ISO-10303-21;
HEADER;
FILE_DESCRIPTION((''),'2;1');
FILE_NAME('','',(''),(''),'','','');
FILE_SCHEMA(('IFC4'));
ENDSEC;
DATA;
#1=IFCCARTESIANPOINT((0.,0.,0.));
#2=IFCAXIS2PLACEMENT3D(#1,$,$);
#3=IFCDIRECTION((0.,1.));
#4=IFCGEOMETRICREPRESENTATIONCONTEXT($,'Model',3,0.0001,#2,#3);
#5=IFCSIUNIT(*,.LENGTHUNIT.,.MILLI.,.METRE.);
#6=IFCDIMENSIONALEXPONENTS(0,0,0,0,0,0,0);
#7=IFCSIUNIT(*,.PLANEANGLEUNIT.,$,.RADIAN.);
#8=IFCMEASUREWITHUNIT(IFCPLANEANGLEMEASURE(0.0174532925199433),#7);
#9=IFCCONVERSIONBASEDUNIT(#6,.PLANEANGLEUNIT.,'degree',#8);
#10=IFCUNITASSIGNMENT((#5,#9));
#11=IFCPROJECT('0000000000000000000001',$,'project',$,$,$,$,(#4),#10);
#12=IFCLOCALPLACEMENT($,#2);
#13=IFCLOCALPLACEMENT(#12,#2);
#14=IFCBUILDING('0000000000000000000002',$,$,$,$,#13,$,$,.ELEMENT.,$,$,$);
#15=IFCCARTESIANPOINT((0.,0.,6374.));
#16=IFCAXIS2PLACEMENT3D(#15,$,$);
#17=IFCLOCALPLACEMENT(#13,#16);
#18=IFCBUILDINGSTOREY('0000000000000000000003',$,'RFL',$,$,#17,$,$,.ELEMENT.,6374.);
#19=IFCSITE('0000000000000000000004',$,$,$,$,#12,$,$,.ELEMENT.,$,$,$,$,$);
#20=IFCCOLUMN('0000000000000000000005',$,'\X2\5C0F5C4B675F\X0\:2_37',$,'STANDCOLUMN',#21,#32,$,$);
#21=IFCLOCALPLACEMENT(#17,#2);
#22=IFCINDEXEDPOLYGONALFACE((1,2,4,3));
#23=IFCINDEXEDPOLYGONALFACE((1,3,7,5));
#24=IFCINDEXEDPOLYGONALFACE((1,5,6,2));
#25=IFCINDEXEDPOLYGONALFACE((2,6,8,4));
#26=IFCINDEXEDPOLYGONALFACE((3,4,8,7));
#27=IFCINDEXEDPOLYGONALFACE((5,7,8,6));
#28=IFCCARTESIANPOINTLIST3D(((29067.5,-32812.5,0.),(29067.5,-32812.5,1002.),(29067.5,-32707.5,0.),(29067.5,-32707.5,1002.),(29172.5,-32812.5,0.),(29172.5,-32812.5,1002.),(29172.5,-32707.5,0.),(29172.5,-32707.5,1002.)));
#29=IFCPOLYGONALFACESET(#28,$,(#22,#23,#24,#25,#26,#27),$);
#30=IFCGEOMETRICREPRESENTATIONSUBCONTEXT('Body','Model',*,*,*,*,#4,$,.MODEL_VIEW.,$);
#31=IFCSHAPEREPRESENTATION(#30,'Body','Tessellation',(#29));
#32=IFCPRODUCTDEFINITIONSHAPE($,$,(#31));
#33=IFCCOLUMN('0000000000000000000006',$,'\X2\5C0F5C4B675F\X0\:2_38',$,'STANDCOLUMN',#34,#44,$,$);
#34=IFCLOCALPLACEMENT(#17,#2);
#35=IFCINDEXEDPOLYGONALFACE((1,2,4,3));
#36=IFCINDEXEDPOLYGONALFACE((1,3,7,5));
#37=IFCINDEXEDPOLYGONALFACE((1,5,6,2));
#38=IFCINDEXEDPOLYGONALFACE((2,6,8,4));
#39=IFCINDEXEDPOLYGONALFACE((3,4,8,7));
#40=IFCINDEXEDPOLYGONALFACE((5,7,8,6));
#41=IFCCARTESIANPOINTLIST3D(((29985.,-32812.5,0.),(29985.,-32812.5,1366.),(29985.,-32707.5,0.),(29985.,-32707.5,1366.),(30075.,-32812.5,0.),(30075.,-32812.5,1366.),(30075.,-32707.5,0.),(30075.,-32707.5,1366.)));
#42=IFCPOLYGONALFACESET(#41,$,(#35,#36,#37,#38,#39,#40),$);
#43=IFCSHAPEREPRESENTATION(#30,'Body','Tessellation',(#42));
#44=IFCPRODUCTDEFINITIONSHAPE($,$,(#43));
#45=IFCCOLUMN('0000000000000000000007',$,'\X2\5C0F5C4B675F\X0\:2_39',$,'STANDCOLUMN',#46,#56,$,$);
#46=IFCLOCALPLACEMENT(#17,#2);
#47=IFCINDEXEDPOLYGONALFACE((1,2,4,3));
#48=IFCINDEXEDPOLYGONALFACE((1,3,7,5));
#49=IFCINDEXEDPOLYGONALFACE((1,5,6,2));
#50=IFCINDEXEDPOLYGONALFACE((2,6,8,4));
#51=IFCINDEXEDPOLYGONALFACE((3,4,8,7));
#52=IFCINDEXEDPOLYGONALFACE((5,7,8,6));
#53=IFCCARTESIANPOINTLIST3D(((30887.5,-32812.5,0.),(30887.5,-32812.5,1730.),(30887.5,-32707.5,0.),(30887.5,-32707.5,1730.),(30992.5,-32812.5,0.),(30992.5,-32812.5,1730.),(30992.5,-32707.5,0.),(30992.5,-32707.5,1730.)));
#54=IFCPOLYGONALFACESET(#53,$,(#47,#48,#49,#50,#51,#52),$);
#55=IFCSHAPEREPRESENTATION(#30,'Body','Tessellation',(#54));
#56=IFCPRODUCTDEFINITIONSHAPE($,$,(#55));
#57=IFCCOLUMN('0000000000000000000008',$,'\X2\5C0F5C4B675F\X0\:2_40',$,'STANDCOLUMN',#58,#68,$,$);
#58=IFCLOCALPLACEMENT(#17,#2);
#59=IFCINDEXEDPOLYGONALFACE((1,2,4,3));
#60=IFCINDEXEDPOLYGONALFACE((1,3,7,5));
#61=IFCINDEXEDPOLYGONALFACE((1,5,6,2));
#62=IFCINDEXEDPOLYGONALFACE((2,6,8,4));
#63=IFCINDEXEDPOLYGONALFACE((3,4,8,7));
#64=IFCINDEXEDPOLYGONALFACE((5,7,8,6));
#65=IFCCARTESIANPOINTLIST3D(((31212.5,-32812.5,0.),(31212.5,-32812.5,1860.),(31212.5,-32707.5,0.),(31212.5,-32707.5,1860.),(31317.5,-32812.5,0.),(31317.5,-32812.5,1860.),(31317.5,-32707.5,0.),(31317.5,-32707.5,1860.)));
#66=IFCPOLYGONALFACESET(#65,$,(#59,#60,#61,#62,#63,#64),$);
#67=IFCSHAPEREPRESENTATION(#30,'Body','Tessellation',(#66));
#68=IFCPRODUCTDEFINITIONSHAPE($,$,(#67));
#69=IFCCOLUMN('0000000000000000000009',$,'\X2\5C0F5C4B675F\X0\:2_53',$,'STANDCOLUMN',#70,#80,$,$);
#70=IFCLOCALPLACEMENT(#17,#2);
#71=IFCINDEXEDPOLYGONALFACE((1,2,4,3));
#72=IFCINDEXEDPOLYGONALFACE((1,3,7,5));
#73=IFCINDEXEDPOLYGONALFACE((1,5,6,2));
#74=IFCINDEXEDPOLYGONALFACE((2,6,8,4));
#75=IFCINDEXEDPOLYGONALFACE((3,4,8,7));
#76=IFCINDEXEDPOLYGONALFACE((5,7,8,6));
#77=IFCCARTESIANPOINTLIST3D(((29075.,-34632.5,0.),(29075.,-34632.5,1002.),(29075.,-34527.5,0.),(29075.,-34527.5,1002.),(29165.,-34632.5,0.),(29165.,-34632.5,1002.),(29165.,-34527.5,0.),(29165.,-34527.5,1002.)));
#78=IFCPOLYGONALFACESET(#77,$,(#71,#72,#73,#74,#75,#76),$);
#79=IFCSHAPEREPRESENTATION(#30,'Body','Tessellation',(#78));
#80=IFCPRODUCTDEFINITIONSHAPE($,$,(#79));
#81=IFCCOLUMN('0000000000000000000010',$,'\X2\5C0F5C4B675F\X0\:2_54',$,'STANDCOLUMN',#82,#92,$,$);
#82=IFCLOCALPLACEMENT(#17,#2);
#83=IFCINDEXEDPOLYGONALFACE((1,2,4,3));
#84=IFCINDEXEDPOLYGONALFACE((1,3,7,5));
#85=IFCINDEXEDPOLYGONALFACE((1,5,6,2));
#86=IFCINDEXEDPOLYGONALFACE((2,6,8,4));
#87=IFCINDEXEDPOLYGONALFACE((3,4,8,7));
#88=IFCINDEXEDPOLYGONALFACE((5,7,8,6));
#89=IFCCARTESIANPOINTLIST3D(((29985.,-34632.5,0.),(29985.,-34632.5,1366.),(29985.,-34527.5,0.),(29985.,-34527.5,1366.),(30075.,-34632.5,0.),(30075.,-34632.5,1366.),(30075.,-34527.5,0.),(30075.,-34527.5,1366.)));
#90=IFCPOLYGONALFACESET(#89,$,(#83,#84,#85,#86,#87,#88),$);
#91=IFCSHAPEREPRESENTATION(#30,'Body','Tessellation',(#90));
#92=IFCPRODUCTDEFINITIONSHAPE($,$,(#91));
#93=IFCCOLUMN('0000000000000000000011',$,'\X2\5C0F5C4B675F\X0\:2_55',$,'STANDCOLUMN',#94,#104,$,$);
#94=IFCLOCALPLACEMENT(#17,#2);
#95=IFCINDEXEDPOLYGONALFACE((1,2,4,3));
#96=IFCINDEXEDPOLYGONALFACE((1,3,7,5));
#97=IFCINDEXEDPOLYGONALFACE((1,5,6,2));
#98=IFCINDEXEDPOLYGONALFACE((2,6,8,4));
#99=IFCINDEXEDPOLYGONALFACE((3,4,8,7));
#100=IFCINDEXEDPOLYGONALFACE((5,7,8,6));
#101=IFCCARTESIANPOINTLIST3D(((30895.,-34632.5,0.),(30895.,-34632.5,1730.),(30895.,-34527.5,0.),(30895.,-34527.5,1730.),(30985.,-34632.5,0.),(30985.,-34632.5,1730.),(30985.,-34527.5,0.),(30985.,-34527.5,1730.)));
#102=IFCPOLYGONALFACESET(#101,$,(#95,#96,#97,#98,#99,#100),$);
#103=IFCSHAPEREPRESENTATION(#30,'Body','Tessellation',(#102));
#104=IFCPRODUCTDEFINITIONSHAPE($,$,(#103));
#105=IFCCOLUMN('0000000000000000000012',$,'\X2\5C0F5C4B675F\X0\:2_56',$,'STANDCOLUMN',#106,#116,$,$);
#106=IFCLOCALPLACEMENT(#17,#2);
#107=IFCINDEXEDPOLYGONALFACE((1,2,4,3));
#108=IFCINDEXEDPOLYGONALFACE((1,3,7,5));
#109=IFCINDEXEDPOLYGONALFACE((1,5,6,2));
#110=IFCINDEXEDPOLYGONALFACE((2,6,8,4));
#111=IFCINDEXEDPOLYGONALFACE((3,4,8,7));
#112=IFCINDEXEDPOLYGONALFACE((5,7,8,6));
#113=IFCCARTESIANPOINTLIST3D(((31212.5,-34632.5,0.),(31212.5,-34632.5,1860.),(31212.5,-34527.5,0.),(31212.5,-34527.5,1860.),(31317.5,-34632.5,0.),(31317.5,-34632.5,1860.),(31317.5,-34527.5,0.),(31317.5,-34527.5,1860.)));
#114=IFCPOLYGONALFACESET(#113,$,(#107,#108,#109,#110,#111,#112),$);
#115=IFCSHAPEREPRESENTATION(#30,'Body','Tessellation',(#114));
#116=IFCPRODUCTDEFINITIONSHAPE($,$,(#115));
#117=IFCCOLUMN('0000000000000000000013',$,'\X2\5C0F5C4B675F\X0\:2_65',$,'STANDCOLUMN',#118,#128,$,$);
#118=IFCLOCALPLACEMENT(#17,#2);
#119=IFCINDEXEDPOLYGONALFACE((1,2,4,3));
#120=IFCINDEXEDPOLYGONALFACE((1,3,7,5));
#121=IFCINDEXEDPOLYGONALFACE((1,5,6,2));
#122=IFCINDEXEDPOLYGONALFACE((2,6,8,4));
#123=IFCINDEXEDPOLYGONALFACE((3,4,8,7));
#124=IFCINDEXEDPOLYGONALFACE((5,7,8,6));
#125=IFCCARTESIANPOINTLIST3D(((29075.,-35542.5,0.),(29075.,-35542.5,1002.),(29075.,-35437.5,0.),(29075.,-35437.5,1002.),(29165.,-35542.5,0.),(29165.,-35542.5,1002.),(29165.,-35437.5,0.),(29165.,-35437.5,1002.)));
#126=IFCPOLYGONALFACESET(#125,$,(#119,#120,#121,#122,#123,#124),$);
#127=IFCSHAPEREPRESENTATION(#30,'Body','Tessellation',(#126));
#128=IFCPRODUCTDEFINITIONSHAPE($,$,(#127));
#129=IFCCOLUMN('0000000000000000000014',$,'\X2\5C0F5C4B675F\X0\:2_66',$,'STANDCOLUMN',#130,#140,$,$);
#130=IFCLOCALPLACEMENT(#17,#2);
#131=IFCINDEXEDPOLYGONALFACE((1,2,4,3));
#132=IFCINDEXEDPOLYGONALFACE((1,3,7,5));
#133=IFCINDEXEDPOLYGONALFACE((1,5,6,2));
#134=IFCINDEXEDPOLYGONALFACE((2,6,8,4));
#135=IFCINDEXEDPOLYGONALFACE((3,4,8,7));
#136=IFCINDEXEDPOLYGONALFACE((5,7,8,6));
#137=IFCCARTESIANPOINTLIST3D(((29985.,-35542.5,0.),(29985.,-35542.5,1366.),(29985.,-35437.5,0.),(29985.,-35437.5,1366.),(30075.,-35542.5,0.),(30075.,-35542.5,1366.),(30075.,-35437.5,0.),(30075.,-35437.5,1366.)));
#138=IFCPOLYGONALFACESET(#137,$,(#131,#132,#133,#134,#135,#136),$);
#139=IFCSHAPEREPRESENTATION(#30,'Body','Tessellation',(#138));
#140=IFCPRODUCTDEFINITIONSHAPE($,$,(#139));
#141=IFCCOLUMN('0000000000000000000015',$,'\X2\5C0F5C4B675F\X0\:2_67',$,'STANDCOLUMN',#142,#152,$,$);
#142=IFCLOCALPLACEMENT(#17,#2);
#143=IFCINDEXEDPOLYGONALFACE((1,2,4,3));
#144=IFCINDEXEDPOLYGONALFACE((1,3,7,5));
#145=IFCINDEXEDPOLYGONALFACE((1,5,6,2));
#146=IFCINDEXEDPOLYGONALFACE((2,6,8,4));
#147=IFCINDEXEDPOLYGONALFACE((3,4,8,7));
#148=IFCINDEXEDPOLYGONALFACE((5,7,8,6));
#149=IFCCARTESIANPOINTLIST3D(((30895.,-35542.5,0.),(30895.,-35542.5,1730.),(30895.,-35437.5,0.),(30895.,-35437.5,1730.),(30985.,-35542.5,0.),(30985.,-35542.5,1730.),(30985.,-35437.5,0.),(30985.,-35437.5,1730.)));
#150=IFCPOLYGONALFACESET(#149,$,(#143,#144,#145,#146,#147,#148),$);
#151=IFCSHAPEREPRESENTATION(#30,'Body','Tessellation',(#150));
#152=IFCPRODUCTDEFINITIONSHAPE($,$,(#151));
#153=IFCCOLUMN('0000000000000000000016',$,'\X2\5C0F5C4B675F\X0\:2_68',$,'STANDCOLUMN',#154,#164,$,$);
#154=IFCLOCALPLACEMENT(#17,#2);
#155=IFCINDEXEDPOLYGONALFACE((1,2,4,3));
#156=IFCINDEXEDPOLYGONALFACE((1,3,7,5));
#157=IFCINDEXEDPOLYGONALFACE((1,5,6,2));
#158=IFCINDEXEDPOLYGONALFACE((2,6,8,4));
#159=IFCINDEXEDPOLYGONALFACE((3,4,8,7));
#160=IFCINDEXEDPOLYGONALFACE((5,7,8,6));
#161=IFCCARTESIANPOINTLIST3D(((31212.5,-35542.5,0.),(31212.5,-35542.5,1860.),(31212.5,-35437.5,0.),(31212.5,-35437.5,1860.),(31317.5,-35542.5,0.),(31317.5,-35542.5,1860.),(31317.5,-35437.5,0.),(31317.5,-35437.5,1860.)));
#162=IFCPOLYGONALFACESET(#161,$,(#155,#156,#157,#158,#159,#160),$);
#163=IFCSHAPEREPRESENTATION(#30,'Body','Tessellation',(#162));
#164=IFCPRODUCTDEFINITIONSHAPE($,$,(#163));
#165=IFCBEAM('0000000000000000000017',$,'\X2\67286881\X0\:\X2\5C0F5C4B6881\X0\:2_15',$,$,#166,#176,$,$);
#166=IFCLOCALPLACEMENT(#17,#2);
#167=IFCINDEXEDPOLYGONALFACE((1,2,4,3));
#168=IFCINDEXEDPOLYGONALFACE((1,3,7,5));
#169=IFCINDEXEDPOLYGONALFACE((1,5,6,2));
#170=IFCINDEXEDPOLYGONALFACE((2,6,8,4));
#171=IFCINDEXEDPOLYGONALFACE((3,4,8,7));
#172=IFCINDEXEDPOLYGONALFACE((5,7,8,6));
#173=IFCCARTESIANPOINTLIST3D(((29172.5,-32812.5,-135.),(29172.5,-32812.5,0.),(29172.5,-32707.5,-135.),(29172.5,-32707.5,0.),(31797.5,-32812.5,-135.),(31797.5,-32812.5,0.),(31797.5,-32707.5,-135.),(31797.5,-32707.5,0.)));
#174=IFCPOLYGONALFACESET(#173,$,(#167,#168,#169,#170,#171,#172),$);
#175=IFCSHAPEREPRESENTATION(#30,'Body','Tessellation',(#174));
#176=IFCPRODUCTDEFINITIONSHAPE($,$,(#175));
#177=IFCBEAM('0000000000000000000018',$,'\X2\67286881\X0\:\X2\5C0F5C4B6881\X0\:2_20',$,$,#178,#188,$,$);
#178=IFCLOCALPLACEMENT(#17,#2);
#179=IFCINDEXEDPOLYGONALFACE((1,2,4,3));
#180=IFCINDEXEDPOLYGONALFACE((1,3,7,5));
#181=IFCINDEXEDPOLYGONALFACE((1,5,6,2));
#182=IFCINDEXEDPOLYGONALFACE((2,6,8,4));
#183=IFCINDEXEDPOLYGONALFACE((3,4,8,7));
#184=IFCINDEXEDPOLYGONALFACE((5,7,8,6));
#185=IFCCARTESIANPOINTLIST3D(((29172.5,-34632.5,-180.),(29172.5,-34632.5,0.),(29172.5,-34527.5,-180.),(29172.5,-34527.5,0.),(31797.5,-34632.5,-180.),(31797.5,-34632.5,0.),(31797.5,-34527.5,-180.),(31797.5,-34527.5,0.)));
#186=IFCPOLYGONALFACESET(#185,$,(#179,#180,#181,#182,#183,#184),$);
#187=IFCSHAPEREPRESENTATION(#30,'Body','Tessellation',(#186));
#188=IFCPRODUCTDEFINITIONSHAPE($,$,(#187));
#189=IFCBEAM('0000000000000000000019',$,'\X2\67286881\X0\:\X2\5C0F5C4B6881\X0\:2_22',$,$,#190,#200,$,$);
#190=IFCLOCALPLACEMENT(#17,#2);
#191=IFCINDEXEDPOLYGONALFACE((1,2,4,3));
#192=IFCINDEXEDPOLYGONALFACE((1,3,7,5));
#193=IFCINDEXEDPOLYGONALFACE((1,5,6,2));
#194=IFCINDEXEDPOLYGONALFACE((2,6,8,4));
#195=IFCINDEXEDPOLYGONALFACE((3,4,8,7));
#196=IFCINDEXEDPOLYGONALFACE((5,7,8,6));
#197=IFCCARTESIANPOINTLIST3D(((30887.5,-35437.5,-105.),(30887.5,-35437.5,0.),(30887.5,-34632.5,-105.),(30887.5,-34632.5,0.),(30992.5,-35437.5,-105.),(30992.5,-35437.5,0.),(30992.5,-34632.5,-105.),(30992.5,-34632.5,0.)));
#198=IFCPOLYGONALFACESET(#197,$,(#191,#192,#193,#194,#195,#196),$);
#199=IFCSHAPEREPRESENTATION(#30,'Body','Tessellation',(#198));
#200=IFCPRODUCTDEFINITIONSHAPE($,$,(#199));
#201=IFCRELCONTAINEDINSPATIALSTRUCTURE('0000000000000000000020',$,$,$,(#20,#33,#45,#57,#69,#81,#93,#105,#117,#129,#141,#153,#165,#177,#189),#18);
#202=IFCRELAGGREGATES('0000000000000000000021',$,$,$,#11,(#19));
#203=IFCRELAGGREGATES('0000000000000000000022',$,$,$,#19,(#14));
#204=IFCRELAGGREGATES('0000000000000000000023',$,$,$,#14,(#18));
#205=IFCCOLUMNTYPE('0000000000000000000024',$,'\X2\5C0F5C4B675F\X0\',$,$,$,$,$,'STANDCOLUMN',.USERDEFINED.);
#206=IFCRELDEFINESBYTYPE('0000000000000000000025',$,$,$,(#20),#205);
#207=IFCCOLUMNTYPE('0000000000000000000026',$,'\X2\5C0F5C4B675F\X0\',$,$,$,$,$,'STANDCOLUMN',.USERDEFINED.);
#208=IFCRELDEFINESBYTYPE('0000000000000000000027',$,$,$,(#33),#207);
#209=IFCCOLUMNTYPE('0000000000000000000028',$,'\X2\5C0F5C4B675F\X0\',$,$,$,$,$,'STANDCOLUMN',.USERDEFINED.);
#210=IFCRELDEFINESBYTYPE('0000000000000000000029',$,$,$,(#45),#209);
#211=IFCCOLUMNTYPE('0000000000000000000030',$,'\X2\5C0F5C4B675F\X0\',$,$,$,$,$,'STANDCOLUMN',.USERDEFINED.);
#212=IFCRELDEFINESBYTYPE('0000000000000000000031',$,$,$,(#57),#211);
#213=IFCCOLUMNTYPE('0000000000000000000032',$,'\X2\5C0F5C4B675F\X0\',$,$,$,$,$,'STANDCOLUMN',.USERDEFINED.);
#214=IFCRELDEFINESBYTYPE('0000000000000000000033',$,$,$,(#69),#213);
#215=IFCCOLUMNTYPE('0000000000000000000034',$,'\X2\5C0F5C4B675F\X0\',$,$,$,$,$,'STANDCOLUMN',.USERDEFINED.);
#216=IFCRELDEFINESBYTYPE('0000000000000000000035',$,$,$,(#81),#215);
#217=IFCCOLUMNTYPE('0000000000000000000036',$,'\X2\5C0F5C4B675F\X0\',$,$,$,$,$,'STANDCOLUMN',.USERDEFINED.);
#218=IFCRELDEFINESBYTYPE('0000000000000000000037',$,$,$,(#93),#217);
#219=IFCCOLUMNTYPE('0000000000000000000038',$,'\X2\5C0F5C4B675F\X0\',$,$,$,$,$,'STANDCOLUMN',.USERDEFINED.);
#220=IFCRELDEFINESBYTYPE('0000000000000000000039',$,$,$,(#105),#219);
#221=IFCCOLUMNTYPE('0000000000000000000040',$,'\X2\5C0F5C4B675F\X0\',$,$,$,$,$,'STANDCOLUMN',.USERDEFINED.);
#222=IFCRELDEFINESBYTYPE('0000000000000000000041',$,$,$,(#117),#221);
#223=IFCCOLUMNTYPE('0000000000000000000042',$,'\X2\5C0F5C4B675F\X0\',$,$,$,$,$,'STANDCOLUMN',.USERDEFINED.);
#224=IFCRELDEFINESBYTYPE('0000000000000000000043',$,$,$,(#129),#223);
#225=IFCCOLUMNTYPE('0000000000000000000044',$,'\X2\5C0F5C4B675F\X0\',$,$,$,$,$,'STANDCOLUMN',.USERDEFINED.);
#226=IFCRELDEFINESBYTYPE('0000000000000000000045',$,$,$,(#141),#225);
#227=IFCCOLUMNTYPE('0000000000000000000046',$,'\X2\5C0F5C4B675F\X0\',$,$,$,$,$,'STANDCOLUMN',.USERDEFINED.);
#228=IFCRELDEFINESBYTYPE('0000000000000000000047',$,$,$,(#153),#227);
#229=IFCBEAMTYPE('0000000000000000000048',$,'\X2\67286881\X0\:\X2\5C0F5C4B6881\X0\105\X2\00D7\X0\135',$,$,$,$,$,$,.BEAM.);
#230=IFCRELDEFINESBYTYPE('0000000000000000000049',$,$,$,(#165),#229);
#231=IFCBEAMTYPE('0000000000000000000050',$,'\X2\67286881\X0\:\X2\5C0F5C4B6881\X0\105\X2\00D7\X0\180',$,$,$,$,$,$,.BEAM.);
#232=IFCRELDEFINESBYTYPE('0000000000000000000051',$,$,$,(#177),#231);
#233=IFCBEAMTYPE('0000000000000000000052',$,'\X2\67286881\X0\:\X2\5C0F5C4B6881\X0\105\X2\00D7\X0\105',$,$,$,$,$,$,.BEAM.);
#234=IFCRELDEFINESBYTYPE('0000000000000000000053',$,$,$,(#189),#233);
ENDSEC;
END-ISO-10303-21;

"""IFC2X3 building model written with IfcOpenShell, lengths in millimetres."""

from ifc_helpers import new_model, entity, si_unit, converted_unit, direction, frame, origin, origin_with_axes, origin_2d, place, context, subcontext, project, spatial, rectangle, extrude, type_object, element, save


model = new_model("IFC2X3")

# Units and contexts
model_context = context("Model", 3, precision=0.0001, world=origin(), true_north=direction((0.0, 1.0)))
body_context = subcontext(model_context, "Body", "Model", "MODEL_VIEW")
ifc_project = project(units=[si_unit("LENGTHUNIT", "METRE", prefix="MILLI"), converted_unit("PLANEANGLEUNIT", "degree", entity("IfcPlaneAngleMeasure", 0.0174532925199433), si_unit("PLANEANGLEUNIT", "RADIAN"), dimensions=[0, 0, 0, 0, 0, 0, 0])], contexts=[model_context])

# Site, building, storey
site_placement = place(None, origin())
site = spatial("IfcSite", under=ifc_project, at=site_placement, CompositionType="ELEMENT")
building_placement = place(site_placement, origin())
building = spatial("IfcBuilding", under=site, at=building_placement, CompositionType="ELEMENT")
storey_placement = place(building_placement, frame((0.0, 0.0, 6374.0)))
storey = spatial("IfcBuildingStorey", under=building, at=storey_placement, Name="RFL", CompositionType="ELEMENT", Elevation=6374.0)

# Columns
column_type_1 = type_object("IfcColumnType", Name="小屋束", ElementType="STANDCOLUMN", PredefinedType="USERDEFINED")
column_1_placement = place(storey_placement, frame((29120.0, -32760.0, 0.0)))
element("IfcColumn", 1, at=column_1_placement, inside=storey, type_object=column_type_1, Name="小屋束:2_37", ObjectType="STANDCOLUMN", context=body_context, shape_type="SweptSolid", body=[
    extrude(rectangle(XDim=105.0, YDim=105.0, at=origin_2d()), origin_with_axes(), (0.0, 0.0, 1.0), 1002.0),
])
column_type_2 = type_object("IfcColumnType", Name="小屋束", ElementType="STANDCOLUMN", PredefinedType="USERDEFINED")
column_2_placement = place(storey_placement, frame((30030.0, -32760.0, 0.0)))
element("IfcColumn", 2, at=column_2_placement, inside=storey, type_object=column_type_2, Name="小屋束:2_38", ObjectType="STANDCOLUMN", context=body_context, shape_type="SweptSolid", body=[
    extrude(rectangle(XDim=90.0, YDim=105.0, at=origin_2d()), origin_with_axes(), (0.0, 0.0, 1.0), 1366.0),
])
column_type_3 = type_object("IfcColumnType", Name="小屋束", ElementType="STANDCOLUMN", PredefinedType="USERDEFINED")
column_3_placement = place(storey_placement, frame((30940.0, -32760.0, 0.0)))
element("IfcColumn", 3, at=column_3_placement, inside=storey, type_object=column_type_3, Name="小屋束:2_39", ObjectType="STANDCOLUMN", context=body_context, shape_type="SweptSolid", body=[
    extrude(rectangle(XDim=105.0, YDim=105.0, at=origin_2d()), origin_with_axes(), (0.0, 0.0, 1.0), 1730.0),
])
column_type_4 = type_object("IfcColumnType", Name="小屋束", ElementType="STANDCOLUMN", PredefinedType="USERDEFINED")
column_4_placement = place(storey_placement, frame((31265.0, -32760.0, 0.0)))
element("IfcColumn", 4, at=column_4_placement, inside=storey, type_object=column_type_4, Name="小屋束:2_40", ObjectType="STANDCOLUMN", context=body_context, shape_type="SweptSolid", body=[
    extrude(rectangle(XDim=105.0, YDim=105.0, at=origin_2d()), origin_with_axes(), (0.0, 0.0, 1.0), 1860.0),
])
column_type_5 = type_object("IfcColumnType", Name="小屋束", ElementType="STANDCOLUMN", PredefinedType="USERDEFINED")
column_5_placement = place(storey_placement, frame((29120.0, -34580.0, 0.0)))
element("IfcColumn", 5, at=column_5_placement, inside=storey, type_object=column_type_5, Name="小屋束:2_53", ObjectType="STANDCOLUMN", context=body_context, shape_type="SweptSolid", body=[
    extrude(rectangle(XDim=90.0, YDim=105.0, at=origin_2d()), origin_with_axes(), (0.0, 0.0, 1.0), 1002.0),
])
column_type_6 = type_object("IfcColumnType", Name="小屋束", ElementType="STANDCOLUMN", PredefinedType="USERDEFINED")
column_6_placement = place(storey_placement, frame((30030.0, -34580.0, 0.0)))
element("IfcColumn", 6, at=column_6_placement, inside=storey, type_object=column_type_6, Name="小屋束:2_54", ObjectType="STANDCOLUMN", context=body_context, shape_type="SweptSolid", body=[
    extrude(rectangle(XDim=90.0, YDim=105.0, at=origin_2d()), origin_with_axes(), (0.0, 0.0, 1.0), 1366.0),
])
column_type_7 = type_object("IfcColumnType", Name="小屋束", ElementType="STANDCOLUMN", PredefinedType="USERDEFINED")
column_7_placement = place(storey_placement, frame((30940.0, -34580.0, 0.0)))
element("IfcColumn", 7, at=column_7_placement, inside=storey, type_object=column_type_7, Name="小屋束:2_55", ObjectType="STANDCOLUMN", context=body_context, shape_type="SweptSolid", body=[
    extrude(rectangle(XDim=90.0, YDim=105.0, at=origin_2d()), origin_with_axes(), (0.0, 0.0, 1.0), 1730.0),
])
column_type_8 = type_object("IfcColumnType", Name="小屋束", ElementType="STANDCOLUMN", PredefinedType="USERDEFINED")
column_8_placement = place(storey_placement, frame((31265.0, -34580.0, 0.0)))
element("IfcColumn", 8, at=column_8_placement, inside=storey, type_object=column_type_8, Name="小屋束:2_56", ObjectType="STANDCOLUMN", context=body_context, shape_type="SweptSolid", body=[
    extrude(rectangle(XDim=105.0, YDim=105.0, at=origin_2d()), origin_with_axes(), (0.0, 0.0, 1.0), 1860.0),
])
column_type_9 = type_object("IfcColumnType", Name="小屋束", ElementType="STANDCOLUMN", PredefinedType="USERDEFINED")
column_9_placement = place(storey_placement, frame((29120.0, -35490.0, 0.0)))
element("IfcColumn", 9, at=column_9_placement, inside=storey, type_object=column_type_9, Name="小屋束:2_65", ObjectType="STANDCOLUMN", context=body_context, shape_type="SweptSolid", body=[
    extrude(rectangle(XDim=90.0, YDim=105.0, at=origin_2d()), origin_with_axes(), (0.0, 0.0, 1.0), 1002.0),
])
column_type_10 = type_object("IfcColumnType", Name="小屋束", ElementType="STANDCOLUMN", PredefinedType="USERDEFINED")
column_10_placement = place(storey_placement, frame((30030.0, -35490.0, 0.0)))
element("IfcColumn", 10, at=column_10_placement, inside=storey, type_object=column_type_10, Name="小屋束:2_66", ObjectType="STANDCOLUMN", context=body_context, shape_type="SweptSolid", body=[
    extrude(rectangle(XDim=90.0, YDim=105.0, at=origin_2d()), origin_with_axes(), (0.0, 0.0, 1.0), 1366.0),
])
column_type_11 = type_object("IfcColumnType", Name="小屋束", ElementType="STANDCOLUMN", PredefinedType="USERDEFINED")
column_11_placement = place(storey_placement, frame((30940.0, -35490.0, 0.0)))
element("IfcColumn", 11, at=column_11_placement, inside=storey, type_object=column_type_11, Name="小屋束:2_67", ObjectType="STANDCOLUMN", context=body_context, shape_type="SweptSolid", body=[
    extrude(rectangle(XDim=90.0, YDim=105.0, at=origin_2d()), origin_with_axes(), (0.0, 0.0, 1.0), 1730.0),
])
column_type_12 = type_object("IfcColumnType", Name="小屋束", ElementType="STANDCOLUMN", PredefinedType="USERDEFINED")
column_12_placement = place(storey_placement, frame((31265.0, -35490.0, 0.0)))
element("IfcColumn", 12, at=column_12_placement, inside=storey, type_object=column_type_12, Name="小屋束:2_68", ObjectType="STANDCOLUMN", context=body_context, shape_type="SweptSolid", body=[
    extrude(rectangle(XDim=105.0, YDim=105.0, at=origin_2d()), origin_with_axes(), (0.0, 0.0, 1.0), 1860.0),
])

# Beams
beam_type_1 = type_object("IfcBeamType", Name="木梁:小屋梁105×135", PredefinedType="BEAM")
beam_1_placement = place(storey_placement, frame((29172.5, -32760.0, -67.5), z_axis=(1.0, 0.0, 0.0), x_axis=(0.0, 1.0, 0.0)))
element("IfcBeam", 13, at=beam_1_placement, inside=storey, type_object=beam_type_1, Name="木梁:小屋梁:2_15", context=body_context, shape_type="SweptSolid", body=[
    extrude(rectangle(XDim=105.0, YDim=135.0, at=origin_2d()), origin_with_axes(), (0.0, 0.0, 1.0), 2625.0),
])
beam_type_2 = type_object("IfcBeamType", Name="木梁:小屋梁105×180", PredefinedType="BEAM")
beam_2_placement = place(storey_placement, frame((29172.5, -34580.0, -90.0), z_axis=(1.0, 0.0, 0.0), x_axis=(0.0, 1.0, 0.0)))
element("IfcBeam", 14, at=beam_2_placement, inside=storey, type_object=beam_type_2, Name="木梁:小屋梁:2_20", context=body_context, shape_type="SweptSolid", body=[
    extrude(rectangle(XDim=105.0, YDim=180.0, at=origin_2d()), origin_with_axes(), (0.0, 0.0, 1.0), 2625.0),
])
beam_type_3 = type_object("IfcBeamType", Name="木梁:小屋梁105×105", PredefinedType="BEAM")
beam_3_placement = place(storey_placement, frame((30940.0, -34632.5, -52.5), z_axis=(0.0, -1.0, 0.0), x_axis=(1.0, 0.0, 0.0)))
element("IfcBeam", 15, at=beam_3_placement, inside=storey, type_object=beam_type_3, Name="木梁:小屋梁:2_22", context=body_context, shape_type="SweptSolid", body=[
    extrude(rectangle(XDim=105.0, YDim=105.0, at=origin_2d()), origin_with_axes(), (0.0, 0.0, 1.0), 805.0),
])

save(model, "model.ifc")
